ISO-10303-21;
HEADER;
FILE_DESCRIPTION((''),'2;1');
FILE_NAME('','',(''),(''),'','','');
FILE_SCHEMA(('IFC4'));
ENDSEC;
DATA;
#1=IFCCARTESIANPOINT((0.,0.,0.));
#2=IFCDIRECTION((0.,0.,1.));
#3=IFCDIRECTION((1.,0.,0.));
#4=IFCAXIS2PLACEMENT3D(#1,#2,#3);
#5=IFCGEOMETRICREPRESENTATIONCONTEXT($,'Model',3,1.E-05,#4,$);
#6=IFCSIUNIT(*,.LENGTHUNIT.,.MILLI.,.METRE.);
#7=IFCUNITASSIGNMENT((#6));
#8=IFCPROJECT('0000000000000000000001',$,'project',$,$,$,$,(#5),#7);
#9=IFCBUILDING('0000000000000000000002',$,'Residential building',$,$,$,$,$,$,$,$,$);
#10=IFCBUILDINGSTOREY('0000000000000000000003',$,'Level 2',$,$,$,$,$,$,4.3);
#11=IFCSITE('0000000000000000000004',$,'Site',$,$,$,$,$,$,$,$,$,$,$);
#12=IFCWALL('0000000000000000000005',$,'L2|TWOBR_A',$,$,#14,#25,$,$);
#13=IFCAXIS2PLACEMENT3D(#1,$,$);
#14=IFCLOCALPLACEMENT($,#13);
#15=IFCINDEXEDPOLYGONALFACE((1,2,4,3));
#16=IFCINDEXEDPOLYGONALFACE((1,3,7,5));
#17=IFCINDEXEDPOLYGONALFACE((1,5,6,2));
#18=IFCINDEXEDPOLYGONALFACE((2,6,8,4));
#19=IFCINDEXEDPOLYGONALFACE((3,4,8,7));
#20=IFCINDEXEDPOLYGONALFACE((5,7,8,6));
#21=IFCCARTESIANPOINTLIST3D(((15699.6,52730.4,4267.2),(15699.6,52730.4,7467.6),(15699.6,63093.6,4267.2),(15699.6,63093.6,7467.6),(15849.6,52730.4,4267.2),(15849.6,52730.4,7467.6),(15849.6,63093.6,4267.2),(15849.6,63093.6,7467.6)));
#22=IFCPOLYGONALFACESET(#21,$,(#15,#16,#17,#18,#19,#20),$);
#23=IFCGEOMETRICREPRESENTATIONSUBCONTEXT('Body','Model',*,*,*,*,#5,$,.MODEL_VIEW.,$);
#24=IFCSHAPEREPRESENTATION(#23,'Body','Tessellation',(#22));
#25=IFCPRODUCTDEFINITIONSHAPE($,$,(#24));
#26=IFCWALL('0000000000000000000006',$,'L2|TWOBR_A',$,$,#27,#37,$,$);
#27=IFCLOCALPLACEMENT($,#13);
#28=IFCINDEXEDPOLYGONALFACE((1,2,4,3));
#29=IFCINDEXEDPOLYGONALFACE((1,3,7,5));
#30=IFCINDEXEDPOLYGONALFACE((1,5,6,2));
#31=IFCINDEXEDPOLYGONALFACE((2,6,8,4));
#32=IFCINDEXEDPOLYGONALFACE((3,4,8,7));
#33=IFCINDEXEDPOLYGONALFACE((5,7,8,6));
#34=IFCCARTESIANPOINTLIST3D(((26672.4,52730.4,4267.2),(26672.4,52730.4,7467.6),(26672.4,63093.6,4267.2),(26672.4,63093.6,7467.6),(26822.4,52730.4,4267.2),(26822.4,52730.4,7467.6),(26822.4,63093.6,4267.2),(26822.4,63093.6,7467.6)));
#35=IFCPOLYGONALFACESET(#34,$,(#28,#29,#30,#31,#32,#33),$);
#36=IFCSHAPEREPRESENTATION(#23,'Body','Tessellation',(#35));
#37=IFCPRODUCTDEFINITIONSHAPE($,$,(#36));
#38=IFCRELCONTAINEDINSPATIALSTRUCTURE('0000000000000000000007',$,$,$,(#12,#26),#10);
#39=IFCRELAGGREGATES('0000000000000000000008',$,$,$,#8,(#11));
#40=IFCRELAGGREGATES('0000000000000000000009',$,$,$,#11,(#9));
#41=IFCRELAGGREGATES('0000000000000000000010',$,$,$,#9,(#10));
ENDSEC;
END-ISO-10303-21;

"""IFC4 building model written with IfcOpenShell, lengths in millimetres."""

from ifc_helpers import new_model, si_unit, frame, origin_with_axes, place, context, subcontext, project, spatial, indexed_curve, outline, extrude, element, save


model = new_model("IFC4")

# Units and contexts
model_context = context("Model", 3, precision=1e-05, world=origin_with_axes())
body_context = subcontext(model_context, "Body", "Model", "MODEL_VIEW")
ifc_project = project(units=[si_unit("LENGTHUNIT", "METRE", prefix="MILLI")], contexts=[model_context])

# Site, building, storey
site = spatial("IfcSite", under=ifc_project, Name="Site")
building = spatial("IfcBuilding", under=site, Name="Residential building")
storey = spatial("IfcBuildingStorey", under=building, Name="Level 2", Elevation=4.3)

# Walls
for number, where, z_axis, x_axis, name in (
    (1, (15849.6, 52730.4, 4267.2), (0.0, 0.0, 1.0), (0.0, 1.0, 0.0), "L2|TWOBR_A"),
    (2, (26822.4, 52730.4, 4267.2), (0.0, 0.0, 1.0), (0.0, 1.0, 0.0), "L2|TWOBR_A"),
):
    element("IfcWall", number, at=place(None, frame(where, z_axis=z_axis, x_axis=x_axis)), inside=storey, Name=name, context=body_context, shape_type="SweptSolid", body=[
        extrude(outline(indexed_curve([(0.0, 0.0), (0.0, 150.0), (10363.2, 150.0), (10363.2, 0.0), (0.0, 0.0)], self_intersect=False)), origin_with_axes(), (0.0, 0.0, 1.0), 3200.4),
    ])

save(model, "model.ifc")
